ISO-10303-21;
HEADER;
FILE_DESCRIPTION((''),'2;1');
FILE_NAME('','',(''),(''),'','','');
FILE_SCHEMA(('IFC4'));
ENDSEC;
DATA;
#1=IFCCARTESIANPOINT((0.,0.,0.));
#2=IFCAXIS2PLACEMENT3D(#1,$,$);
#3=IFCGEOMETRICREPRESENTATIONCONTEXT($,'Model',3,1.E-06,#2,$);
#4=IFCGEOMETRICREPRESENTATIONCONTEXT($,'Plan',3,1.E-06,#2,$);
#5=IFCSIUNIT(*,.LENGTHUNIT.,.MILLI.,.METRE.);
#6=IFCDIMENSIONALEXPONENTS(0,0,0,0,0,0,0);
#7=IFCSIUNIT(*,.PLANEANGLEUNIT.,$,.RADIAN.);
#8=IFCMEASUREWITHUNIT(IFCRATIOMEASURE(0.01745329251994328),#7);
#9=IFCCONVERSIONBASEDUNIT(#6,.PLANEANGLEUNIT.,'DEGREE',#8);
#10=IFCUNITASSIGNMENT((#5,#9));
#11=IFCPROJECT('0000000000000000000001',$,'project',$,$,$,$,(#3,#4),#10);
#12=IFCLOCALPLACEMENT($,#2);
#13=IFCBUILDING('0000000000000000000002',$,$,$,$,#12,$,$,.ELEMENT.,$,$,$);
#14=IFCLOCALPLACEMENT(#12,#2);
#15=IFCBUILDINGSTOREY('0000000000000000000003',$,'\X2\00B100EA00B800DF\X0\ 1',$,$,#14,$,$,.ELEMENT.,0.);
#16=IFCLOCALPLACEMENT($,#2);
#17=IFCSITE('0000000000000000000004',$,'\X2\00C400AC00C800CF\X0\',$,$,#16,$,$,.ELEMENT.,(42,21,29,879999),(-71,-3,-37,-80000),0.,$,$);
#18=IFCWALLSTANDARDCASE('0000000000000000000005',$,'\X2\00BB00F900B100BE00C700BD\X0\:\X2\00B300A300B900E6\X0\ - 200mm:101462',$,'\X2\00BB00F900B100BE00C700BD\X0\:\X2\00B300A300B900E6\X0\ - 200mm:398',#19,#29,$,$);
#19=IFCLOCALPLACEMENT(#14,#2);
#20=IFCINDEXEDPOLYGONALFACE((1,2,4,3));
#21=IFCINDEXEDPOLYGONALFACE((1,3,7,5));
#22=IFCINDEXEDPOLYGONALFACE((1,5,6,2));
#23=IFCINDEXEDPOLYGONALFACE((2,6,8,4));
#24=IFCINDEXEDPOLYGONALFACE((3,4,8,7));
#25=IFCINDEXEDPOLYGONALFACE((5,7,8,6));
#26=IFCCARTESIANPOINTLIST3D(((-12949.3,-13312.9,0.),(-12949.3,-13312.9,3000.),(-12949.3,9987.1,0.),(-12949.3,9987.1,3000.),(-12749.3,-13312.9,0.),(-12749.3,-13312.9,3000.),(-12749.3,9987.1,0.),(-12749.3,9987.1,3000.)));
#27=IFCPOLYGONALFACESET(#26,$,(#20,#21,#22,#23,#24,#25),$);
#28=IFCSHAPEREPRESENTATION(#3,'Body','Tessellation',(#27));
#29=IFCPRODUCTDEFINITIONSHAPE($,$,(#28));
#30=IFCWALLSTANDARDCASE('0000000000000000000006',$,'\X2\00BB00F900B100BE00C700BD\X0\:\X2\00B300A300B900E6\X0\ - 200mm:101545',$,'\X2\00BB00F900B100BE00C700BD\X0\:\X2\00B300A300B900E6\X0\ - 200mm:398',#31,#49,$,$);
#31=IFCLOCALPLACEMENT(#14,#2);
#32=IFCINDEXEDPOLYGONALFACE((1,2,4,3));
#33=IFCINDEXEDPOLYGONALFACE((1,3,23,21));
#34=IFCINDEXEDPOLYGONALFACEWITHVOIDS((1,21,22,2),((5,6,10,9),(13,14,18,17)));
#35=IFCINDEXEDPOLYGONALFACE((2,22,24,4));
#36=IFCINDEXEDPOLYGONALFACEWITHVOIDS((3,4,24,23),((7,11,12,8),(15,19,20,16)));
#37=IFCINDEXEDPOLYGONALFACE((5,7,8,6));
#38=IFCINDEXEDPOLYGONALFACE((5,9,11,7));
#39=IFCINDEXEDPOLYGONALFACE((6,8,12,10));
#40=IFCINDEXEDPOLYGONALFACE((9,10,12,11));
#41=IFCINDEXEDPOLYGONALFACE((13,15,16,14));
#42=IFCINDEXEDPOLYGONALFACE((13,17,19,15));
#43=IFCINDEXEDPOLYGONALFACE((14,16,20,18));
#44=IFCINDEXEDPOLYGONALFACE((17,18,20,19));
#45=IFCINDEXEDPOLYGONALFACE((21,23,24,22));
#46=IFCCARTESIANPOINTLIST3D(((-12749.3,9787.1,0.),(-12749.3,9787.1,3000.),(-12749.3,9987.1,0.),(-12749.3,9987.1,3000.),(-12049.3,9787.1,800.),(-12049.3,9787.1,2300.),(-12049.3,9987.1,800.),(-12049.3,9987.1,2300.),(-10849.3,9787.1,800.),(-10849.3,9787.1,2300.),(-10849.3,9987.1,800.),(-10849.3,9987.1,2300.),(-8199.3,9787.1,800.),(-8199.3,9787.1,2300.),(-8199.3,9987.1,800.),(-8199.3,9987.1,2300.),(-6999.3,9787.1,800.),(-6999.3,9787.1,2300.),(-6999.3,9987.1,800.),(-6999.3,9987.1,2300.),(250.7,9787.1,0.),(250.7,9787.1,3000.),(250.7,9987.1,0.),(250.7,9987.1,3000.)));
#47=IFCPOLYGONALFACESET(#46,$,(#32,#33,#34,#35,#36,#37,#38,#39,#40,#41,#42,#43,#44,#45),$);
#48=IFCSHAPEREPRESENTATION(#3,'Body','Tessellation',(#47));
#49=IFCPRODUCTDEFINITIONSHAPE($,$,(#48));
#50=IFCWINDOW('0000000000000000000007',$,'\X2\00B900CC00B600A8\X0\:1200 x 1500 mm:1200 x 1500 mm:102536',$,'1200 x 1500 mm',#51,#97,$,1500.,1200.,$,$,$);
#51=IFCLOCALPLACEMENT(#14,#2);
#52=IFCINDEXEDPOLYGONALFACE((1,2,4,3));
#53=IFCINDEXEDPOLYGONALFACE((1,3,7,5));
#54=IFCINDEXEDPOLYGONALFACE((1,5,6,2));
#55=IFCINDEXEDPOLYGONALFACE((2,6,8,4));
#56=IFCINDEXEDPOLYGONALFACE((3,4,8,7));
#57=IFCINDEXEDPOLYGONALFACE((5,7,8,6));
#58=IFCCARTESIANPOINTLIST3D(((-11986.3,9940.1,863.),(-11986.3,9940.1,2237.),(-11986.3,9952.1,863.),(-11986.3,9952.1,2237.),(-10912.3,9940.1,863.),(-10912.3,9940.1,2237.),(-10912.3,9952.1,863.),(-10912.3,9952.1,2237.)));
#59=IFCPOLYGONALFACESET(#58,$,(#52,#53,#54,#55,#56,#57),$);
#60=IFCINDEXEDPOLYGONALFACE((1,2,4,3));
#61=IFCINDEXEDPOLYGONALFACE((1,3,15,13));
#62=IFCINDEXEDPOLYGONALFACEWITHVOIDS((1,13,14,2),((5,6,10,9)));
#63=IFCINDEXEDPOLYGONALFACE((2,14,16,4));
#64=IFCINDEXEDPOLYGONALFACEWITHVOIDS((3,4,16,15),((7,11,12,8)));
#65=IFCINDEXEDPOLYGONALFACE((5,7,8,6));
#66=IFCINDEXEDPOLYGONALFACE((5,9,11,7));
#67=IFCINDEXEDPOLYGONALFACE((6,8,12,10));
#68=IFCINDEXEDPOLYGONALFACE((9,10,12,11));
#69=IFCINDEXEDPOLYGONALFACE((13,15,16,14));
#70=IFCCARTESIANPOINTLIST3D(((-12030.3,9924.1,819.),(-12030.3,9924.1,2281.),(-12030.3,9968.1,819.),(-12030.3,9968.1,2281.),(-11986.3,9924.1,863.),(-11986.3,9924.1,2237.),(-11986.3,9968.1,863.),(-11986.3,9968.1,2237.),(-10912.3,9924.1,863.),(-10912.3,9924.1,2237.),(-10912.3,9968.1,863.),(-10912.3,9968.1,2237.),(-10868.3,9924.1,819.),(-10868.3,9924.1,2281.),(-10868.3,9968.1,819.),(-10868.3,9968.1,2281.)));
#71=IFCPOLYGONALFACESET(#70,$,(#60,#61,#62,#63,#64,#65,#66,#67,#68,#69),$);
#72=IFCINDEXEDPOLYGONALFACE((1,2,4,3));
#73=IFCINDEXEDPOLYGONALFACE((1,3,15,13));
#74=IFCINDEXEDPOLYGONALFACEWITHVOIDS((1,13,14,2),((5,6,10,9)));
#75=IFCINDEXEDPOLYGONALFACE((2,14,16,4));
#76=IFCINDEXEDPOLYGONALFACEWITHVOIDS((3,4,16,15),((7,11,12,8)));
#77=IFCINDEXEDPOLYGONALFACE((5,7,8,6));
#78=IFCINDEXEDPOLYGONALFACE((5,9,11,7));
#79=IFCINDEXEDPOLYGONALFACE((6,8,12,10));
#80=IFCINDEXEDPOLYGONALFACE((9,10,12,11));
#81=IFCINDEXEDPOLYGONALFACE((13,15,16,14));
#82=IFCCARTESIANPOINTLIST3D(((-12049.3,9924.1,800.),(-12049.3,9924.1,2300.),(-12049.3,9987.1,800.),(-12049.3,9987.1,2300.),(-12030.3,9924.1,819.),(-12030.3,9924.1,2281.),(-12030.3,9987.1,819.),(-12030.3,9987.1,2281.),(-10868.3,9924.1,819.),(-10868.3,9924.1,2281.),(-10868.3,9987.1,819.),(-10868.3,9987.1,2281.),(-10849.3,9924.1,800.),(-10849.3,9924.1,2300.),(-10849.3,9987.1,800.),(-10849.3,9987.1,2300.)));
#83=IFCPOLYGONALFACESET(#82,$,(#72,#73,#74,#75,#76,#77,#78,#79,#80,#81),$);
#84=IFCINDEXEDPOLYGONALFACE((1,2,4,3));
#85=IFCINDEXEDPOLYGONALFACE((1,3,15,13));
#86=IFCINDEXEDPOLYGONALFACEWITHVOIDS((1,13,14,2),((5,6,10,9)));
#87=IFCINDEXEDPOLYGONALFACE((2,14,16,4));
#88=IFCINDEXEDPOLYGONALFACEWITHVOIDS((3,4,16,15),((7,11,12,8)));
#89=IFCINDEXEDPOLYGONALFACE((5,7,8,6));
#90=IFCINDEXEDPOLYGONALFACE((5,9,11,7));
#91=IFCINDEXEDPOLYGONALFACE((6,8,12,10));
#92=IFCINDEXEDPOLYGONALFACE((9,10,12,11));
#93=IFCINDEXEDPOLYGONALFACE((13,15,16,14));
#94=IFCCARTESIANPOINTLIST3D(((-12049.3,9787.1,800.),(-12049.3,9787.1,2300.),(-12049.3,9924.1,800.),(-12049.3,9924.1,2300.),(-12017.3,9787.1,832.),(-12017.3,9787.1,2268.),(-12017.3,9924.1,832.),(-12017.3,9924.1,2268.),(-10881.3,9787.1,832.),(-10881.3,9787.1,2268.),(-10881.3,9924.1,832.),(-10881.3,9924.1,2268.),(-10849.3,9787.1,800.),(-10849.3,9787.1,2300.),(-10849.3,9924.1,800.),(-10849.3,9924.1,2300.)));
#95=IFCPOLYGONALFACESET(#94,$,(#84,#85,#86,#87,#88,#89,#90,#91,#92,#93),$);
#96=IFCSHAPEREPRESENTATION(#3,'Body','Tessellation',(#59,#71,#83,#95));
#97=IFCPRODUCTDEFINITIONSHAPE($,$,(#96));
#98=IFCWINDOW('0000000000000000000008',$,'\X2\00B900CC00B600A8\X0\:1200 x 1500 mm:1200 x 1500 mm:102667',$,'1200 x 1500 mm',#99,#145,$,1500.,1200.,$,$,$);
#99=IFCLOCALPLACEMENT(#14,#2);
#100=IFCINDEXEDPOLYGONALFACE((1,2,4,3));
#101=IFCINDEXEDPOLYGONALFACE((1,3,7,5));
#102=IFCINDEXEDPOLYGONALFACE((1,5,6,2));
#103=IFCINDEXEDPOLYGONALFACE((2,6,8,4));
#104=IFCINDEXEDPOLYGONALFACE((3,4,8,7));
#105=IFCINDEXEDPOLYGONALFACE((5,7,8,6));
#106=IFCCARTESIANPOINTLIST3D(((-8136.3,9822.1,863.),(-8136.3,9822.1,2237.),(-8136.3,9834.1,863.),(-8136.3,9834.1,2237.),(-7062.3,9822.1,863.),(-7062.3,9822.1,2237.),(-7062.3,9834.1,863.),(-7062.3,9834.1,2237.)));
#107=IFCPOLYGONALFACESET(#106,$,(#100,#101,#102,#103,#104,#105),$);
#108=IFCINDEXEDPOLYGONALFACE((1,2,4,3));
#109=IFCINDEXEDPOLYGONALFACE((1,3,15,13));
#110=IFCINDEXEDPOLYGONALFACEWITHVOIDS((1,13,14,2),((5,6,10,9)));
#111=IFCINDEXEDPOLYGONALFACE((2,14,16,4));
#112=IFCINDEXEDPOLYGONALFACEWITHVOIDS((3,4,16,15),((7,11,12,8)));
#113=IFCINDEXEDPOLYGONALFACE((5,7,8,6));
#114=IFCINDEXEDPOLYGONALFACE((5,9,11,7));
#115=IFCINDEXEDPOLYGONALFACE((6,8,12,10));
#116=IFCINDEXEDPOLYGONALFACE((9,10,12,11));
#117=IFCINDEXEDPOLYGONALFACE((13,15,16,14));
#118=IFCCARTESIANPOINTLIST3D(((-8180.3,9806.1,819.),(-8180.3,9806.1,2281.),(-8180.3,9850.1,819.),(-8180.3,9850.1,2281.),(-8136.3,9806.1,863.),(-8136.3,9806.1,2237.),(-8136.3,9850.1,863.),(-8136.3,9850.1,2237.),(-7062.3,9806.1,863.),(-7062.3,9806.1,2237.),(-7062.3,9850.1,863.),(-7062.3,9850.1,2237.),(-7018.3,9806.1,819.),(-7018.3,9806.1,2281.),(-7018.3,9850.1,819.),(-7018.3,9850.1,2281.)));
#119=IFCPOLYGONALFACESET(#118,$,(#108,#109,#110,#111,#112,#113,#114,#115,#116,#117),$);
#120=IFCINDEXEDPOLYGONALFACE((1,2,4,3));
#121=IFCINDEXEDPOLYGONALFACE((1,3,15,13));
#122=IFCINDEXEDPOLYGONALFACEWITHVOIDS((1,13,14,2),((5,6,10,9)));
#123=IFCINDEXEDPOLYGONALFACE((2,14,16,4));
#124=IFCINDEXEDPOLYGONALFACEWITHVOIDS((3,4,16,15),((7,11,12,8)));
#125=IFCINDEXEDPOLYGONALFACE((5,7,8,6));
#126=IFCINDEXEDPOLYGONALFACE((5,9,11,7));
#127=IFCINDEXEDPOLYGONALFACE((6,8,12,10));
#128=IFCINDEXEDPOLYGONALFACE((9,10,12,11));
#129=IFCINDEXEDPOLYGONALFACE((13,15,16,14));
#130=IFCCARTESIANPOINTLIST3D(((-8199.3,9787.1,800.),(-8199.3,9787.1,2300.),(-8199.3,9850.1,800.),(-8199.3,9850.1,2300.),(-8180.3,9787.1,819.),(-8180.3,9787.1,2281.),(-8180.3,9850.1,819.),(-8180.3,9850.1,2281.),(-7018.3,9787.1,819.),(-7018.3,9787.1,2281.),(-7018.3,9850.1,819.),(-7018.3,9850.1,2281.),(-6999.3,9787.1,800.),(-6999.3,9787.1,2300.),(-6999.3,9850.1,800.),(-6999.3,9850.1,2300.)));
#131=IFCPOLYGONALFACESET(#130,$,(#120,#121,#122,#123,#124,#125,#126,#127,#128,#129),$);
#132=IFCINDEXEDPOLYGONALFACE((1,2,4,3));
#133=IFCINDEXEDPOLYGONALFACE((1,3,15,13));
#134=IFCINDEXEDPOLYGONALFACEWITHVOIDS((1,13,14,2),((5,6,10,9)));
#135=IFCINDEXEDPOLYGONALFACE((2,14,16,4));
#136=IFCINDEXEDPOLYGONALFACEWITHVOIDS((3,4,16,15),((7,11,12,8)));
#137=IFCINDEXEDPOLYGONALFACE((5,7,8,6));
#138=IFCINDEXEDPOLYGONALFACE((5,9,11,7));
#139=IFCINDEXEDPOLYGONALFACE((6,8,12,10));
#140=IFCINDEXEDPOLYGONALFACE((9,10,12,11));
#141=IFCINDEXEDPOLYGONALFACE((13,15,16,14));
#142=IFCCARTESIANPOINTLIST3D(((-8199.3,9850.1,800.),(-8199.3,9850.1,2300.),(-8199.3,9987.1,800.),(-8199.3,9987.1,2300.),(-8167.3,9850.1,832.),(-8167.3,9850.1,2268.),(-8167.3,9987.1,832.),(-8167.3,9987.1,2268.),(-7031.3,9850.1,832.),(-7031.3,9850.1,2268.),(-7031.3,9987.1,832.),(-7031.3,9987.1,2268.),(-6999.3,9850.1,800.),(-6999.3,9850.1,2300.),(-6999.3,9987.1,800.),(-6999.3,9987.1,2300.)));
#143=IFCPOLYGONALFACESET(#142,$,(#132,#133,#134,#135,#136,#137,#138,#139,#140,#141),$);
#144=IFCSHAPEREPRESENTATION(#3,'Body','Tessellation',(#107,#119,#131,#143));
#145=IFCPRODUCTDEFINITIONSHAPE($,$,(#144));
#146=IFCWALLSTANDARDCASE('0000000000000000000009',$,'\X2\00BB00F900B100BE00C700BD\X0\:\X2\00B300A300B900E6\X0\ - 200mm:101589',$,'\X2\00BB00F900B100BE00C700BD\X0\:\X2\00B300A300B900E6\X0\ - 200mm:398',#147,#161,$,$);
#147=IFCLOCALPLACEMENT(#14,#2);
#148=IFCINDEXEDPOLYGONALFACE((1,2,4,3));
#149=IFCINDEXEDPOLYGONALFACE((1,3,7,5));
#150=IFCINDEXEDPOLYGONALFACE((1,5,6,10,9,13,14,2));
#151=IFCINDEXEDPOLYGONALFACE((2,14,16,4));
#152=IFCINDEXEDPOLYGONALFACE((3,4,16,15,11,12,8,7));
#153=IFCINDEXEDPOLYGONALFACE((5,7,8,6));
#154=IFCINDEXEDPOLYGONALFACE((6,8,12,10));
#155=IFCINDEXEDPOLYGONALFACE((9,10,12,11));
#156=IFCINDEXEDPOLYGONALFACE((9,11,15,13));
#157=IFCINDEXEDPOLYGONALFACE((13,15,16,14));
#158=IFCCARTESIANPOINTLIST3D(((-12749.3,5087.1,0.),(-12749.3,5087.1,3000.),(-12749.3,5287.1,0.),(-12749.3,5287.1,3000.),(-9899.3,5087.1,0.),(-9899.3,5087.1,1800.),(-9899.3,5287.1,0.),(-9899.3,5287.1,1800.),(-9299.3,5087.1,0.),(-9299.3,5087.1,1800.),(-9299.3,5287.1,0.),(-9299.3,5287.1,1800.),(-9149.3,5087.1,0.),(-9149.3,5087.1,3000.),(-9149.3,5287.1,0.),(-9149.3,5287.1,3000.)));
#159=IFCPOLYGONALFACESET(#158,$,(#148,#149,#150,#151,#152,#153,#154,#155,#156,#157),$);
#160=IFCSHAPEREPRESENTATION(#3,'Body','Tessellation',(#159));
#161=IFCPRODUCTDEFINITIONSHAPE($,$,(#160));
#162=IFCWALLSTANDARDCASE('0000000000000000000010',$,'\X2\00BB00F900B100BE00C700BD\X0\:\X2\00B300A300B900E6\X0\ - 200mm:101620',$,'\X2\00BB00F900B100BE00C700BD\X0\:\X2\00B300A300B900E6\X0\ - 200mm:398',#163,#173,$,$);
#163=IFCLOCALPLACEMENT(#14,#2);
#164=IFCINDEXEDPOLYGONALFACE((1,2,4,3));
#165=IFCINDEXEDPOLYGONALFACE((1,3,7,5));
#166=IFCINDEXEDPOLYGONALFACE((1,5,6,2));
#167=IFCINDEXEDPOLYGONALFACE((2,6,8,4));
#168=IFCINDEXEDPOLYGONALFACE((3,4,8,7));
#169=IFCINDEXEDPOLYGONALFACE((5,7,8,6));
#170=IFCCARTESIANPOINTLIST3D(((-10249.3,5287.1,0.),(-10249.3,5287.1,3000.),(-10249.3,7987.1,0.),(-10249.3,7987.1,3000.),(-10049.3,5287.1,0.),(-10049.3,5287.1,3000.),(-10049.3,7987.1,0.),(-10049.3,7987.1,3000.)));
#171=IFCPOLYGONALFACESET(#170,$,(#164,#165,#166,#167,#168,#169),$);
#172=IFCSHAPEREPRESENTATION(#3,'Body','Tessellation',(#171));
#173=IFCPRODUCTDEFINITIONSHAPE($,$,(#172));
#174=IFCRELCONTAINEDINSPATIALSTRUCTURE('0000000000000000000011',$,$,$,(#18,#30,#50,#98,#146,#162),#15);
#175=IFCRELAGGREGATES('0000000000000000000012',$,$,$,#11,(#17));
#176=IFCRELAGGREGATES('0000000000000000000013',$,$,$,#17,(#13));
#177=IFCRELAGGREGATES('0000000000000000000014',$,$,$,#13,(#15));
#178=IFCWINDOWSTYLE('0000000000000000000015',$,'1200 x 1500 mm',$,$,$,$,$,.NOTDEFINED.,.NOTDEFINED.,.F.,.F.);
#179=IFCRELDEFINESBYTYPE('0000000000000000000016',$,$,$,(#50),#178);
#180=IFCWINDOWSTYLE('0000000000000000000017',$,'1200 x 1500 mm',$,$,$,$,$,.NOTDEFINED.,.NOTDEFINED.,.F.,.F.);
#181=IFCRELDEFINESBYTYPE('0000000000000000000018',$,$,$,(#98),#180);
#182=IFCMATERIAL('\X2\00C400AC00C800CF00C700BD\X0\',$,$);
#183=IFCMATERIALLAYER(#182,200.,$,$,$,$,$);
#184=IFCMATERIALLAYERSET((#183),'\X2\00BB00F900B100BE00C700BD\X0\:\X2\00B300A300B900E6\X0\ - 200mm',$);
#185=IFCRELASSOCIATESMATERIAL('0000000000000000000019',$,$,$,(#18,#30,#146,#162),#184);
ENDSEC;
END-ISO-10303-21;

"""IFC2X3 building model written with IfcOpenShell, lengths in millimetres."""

from ifc_helpers import new_model, entity, si_unit, converted_unit, frame, frame_2d, origin, origin_2d_with_axis, place, context, project, spatial, polyline, rectangle, outline, extrude, source, transform, mapped, material, layer, layer_set, layer_usage, type_object, type_shapes, element, fill, save


model = new_model("IFC2X3")

# Units and contexts
model_context = context("Model", 3, precision=1e-06, world=origin())
plan_context = context("Plan", 3, precision=1e-06, world=origin())
ifc_project = project(units=[si_unit("LENGTHUNIT", "METRE", prefix="MILLI"), converted_unit("PLANEANGLEUNIT", "DEGREE", entity("IfcRatioMeasure", 0.01745329251994328), si_unit("PLANEANGLEUNIT", "RADIAN"), dimensions=[0, 0, 0, 0, 0, 0, 0])], contexts=[model_context, plan_context])

# Site, building, storey
site_placement = place(None, origin())
site = spatial("IfcSite", under=ifc_project, at=site_placement, Name="Ä¬ÈÏ", CompositionType="ELEMENT", RefLatitude=(42, 21, 29, 879999), RefLongitude=(-71, -3, -37, -80000), RefElevation=0.0)
building_placement = place(None, origin())
building = spatial("IfcBuilding", under=site, at=building_placement, CompositionType="ELEMENT")
storey_placement = place(building_placement, origin())
storey = spatial("IfcBuildingStorey", under=building, at=storey_placement, Name="±ê¸ß 1", CompositionType="ELEMENT", Elevation=0.0)

# Wall
ifc_material = material(Name="Ä¬ÈÏÇ½")
ifc_layer = layer(ifc_material, 200.0)
ifc_layer_set = layer_set([ifc_layer], Name="»ù±¾Ç½:³£¹æ - 200mm")
ifc_layer_usage_1 = layer_usage(ifc_layer_set, "AXIS2", "NEGATIVE", 100.0)
wall_1_placement = place(storey_placement, frame((-12849.3, 9987.1, 0.0), z_axis=(0.0, 0.0, 1.0), x_axis=(0.0, -1.0, 0.0)))
element("IfcWallStandardCase", 1, at=wall_1_placement, inside=storey, material=ifc_layer_usage_1, Name="»ù±¾Ç½:³£¹æ - 200mm:101462", ObjectType="»ù±¾Ç½:³£¹æ - 200mm:398", context=model_context, shape_type="SweptSolid", body=[
    extrude(rectangle(XDim=23300.0, YDim=200.0, at=frame_2d((11650.0, 0.0), x_axis=(-1.0, 0.0))), origin(), (0.0, 0.0, 1.0), 3000.0),
])

# Wall, openings, windows
ifc_layer_usage_2 = layer_usage(ifc_layer_set, "AXIS2", "NEGATIVE", 100.0)
wall_2_placement = place(storey_placement, frame((250.7, 9887.1, 0.0), z_axis=(0.0, 0.0, 1.0), x_axis=(-1.0, 0.0, 0.0)))
wall_2 = element("IfcWallStandardCase", 2, at=wall_2_placement, inside=storey, material=ifc_layer_usage_2, Name="»ù±¾Ç½:³£¹æ - 200mm:101545", ObjectType="»ù±¾Ç½:³£¹æ - 200mm:398", context=model_context, shape_type="SweptSolid", body=[
    extrude(rectangle(XDim=13000.0, YDim=200.0, at=frame_2d((6500.0, 0.0), x_axis=(-1.0, 0.0))), origin(), (0.0, 0.0, 1.0), 3000.0),
])
opening_1_placement = place(wall_2_placement, frame((11100.0, -100.0, 800.0)))
opening_1 = element("IfcOpeningElement", 3, at=opening_1_placement, cuts=wall_2, ObjectType="Opening", context=model_context, shape_type="SweptSolid", body=[
    extrude(rectangle(XDim=1500.0, YDim=1200.0, at=frame_2d((750.0, 600.0), x_axis=(1.0, 0.0))), frame((0.0, 0.0, 0.0), z_axis=(0.0, 1.0, 0.0), x_axis=(0.0, 0.0, 1.0)), (0.0, 0.0, 1.0), 200.0),
])
opening_2_placement = place(wall_2_placement, frame((7250.0, -100.0, 800.0)))
opening_2 = element("IfcOpeningElement", 4, at=opening_2_placement, cuts=wall_2, ObjectType="Opening", context=model_context, shape_type="SweptSolid", body=[
    extrude(rectangle(XDim=1500.0, YDim=1200.0, at=frame_2d((750.0, 600.0), x_axis=(1.0, 0.0))), frame((0.0, 0.0, 0.0), z_axis=(0.0, 1.0, 0.0), x_axis=(0.0, 0.0, 1.0)), (0.0, 0.0, 1.0), 200.0),
])
window_style_1 = type_object("IfcWindowStyle", Name="1200 x 1500 mm", ConstructionType="NOTDEFINED", OperationType="NOTDEFINED", ParameterTakesPrecedence=False, Sizeable=False)
shared_shape_1 = source(origin(), model_context, "Body", "SweptSolid", [
    extrude(rectangle(XDim=12.0, YDim=1074.0, at=origin_2d_with_axis()), frame((600.0, 159.0, 63.0), z_axis=(0.0, 0.0, 1.0), x_axis=(0.0, -1.0, 0.0)), (0.0, 0.0, 1.0), 1374.0),
    extrude(outline(polyline([(-581.0, -731.0), (581.0, -731.0), (581.0, 731.0), (-581.0, 731.0), (-581.0, -731.0)]), holes=[polyline([(-537.0, -687.0), (-537.0, 687.0), (537.0, 687.0), (537.0, -687.0), (-537.0, -687.0)])]), frame((600.0, 137.0, 750.0), z_axis=(0.0, 1.0, 0.0), x_axis=(1.0, 0.0, 0.0)), (0.0, 0.0, 1.0), 44.0),
    extrude(outline(polyline([(-600.0, -750.0), (600.0, -750.0), (600.0, 750.0), (-600.0, 750.0), (-600.0, -750.0)]), holes=[polyline([(-581.0, -731.0), (-581.0, 731.0), (581.0, 731.0), (581.0, -731.0), (-581.0, -731.0)])]), frame((600.0, 137.0, 750.0), z_axis=(0.0, 1.0, 0.0), x_axis=(1.0, 0.0, 0.0)), (0.0, 0.0, 1.0), 63.0),
    extrude(outline(polyline([(-600.0, -750.0), (600.0, -750.0), (600.0, 750.0), (-600.0, 750.0), (-600.0, -750.0)]), holes=[polyline([(-568.0, -718.0), (-568.0, 718.0), (568.0, 718.0), (568.0, -718.0), (-568.0, -718.0)])]), frame((600.0, 0.0, 750.0), z_axis=(0.0, 1.0, 0.0), x_axis=(1.0, 0.0, 0.0)), (0.0, 0.0, 1.0), 137.0),
])
type_shapes(window_style_1, [shared_shape_1])
window_1_placement = place(opening_1_placement, frame((1200.0, 200.0, 0.0), z_axis=(0.0, 0.0, 1.0), x_axis=(-1.0, 0.0, 0.0)))
window_1 = element("IfcWindow", 5, at=window_1_placement, inside=storey, type_object=window_style_1, Name="¹Ì¶¨:1200 x 1500 mm:1200 x 1500 mm:102536", ObjectType="1200 x 1500 mm", OverallHeight=1500.0, OverallWidth=1200.0, context=model_context, shape_type="MappedRepresentation", body=[
    mapped(shared_shape_1, transform((0.0, 0.0, 0.0), scale=1.0)),
])
fill(opening_1, window_1)
window_style_2 = type_object("IfcWindowStyle", Name="1200 x 1500 mm", ConstructionType="NOTDEFINED", OperationType="NOTDEFINED", ParameterTakesPrecedence=False, Sizeable=False)
shared_shape_2 = source(origin(), model_context, "Body", "SweptSolid", [
    extrude(rectangle(XDim=12.0, YDim=1074.0, at=origin_2d_with_axis()), frame((600.0, 159.0, 63.0), z_axis=(0.0, 0.0, 1.0), x_axis=(0.0, -1.0, 0.0)), (0.0, 0.0, 1.0), 1374.0),
    extrude(outline(polyline([(-581.0, -731.0), (581.0, -731.0), (581.0, 731.0), (-581.0, 731.0), (-581.0, -731.0)]), holes=[polyline([(-537.0, -687.0), (-537.0, 687.0), (537.0, 687.0), (537.0, -687.0), (-537.0, -687.0)])]), frame((600.0, 137.0, 750.0), z_axis=(0.0, 1.0, 0.0), x_axis=(1.0, 0.0, 0.0)), (0.0, 0.0, 1.0), 44.0),
    extrude(outline(polyline([(-600.0, -750.0), (600.0, -750.0), (600.0, 750.0), (-600.0, 750.0), (-600.0, -750.0)]), holes=[polyline([(-581.0, -731.0), (-581.0, 731.0), (581.0, 731.0), (581.0, -731.0), (-581.0, -731.0)])]), frame((600.0, 137.0, 750.0), z_axis=(0.0, 1.0, 0.0), x_axis=(1.0, 0.0, 0.0)), (0.0, 0.0, 1.0), 63.0),
    extrude(outline(polyline([(-600.0, -750.0), (600.0, -750.0), (600.0, 750.0), (-600.0, 750.0), (-600.0, -750.0)]), holes=[polyline([(-568.0, -718.0), (-568.0, 718.0), (568.0, 718.0), (568.0, -718.0), (-568.0, -718.0)])]), frame((600.0, 0.0, 750.0), z_axis=(0.0, 1.0, 0.0), x_axis=(1.0, 0.0, 0.0)), (0.0, 0.0, 1.0), 137.0),
])
type_shapes(window_style_2, [shared_shape_2])
window_2_placement = place(opening_2_placement, origin())
window_2 = element("IfcWindow", 6, at=window_2_placement, inside=storey, type_object=window_style_2, Name="¹Ì¶¨:1200 x 1500 mm:1200 x 1500 mm:102667", ObjectType="1200 x 1500 mm", OverallHeight=1500.0, OverallWidth=1200.0, context=model_context, shape_type="MappedRepresentation", body=[
    mapped(shared_shape_2, transform((0.0, 0.0, 0.0), scale=1.0)),
])
fill(opening_2, window_2)

# Wall, opening
ifc_layer_usage_3 = layer_usage(ifc_layer_set, "AXIS2", "NEGATIVE", 100.0)
wall_3_placement = place(storey_placement, frame((-12749.3, 5187.1, 0.0)))
wall_3 = element("IfcWallStandardCase", 7, at=wall_3_placement, inside=storey, material=ifc_layer_usage_3, Name="»ù±¾Ç½:³£¹æ - 200mm:101589", ObjectType="»ù±¾Ç½:³£¹æ - 200mm:398", context=model_context, shape_type="SweptSolid", body=[
    extrude(rectangle(XDim=3600.0, YDim=200.0, at=frame_2d((1800.0, 0.0), x_axis=(-1.0, 0.0))), origin(), (0.0, 0.0, 1.0), 3000.0),
])
opening_3_placement = place(wall_3_placement, frame((3450.0, 100.0, 0.0)))
element("IfcOpeningElement", 8, at=opening_3_placement, cuts=wall_3, ObjectType="Opening", context=model_context, shape_type="SweptSolid", body=[
    extrude(rectangle(XDim=1800.0, YDim=600.0, at=frame_2d((900.0, 300.0), x_axis=(1.0, 0.0))), frame((0.0, 0.0, 0.0), z_axis=(0.0, -1.0, 0.0), x_axis=(0.0, 0.0, 1.0)), (0.0, 0.0, 1.0), 200.0),
])

# Wall
ifc_layer_usage_4 = layer_usage(ifc_layer_set, "AXIS2", "NEGATIVE", 100.0)
wall_4_placement = place(storey_placement, frame((-10149.3, 5287.1, 0.0), z_axis=(0.0, 0.0, 1.0), x_axis=(0.0, 1.0, 0.0)))
element("IfcWallStandardCase", 9, at=wall_4_placement, inside=storey, material=ifc_layer_usage_4, Name="»ù±¾Ç½:³£¹æ - 200mm:101620", ObjectType="»ù±¾Ç½:³£¹æ - 200mm:398", context=model_context, shape_type="SweptSolid", body=[
    extrude(rectangle(XDim=2700.0, YDim=200.0, at=frame_2d((1350.0, 0.0), x_axis=(-1.0, 0.0))), origin(), (0.0, 0.0, 1.0), 3000.0),
])

save(model, "model.ifc")
